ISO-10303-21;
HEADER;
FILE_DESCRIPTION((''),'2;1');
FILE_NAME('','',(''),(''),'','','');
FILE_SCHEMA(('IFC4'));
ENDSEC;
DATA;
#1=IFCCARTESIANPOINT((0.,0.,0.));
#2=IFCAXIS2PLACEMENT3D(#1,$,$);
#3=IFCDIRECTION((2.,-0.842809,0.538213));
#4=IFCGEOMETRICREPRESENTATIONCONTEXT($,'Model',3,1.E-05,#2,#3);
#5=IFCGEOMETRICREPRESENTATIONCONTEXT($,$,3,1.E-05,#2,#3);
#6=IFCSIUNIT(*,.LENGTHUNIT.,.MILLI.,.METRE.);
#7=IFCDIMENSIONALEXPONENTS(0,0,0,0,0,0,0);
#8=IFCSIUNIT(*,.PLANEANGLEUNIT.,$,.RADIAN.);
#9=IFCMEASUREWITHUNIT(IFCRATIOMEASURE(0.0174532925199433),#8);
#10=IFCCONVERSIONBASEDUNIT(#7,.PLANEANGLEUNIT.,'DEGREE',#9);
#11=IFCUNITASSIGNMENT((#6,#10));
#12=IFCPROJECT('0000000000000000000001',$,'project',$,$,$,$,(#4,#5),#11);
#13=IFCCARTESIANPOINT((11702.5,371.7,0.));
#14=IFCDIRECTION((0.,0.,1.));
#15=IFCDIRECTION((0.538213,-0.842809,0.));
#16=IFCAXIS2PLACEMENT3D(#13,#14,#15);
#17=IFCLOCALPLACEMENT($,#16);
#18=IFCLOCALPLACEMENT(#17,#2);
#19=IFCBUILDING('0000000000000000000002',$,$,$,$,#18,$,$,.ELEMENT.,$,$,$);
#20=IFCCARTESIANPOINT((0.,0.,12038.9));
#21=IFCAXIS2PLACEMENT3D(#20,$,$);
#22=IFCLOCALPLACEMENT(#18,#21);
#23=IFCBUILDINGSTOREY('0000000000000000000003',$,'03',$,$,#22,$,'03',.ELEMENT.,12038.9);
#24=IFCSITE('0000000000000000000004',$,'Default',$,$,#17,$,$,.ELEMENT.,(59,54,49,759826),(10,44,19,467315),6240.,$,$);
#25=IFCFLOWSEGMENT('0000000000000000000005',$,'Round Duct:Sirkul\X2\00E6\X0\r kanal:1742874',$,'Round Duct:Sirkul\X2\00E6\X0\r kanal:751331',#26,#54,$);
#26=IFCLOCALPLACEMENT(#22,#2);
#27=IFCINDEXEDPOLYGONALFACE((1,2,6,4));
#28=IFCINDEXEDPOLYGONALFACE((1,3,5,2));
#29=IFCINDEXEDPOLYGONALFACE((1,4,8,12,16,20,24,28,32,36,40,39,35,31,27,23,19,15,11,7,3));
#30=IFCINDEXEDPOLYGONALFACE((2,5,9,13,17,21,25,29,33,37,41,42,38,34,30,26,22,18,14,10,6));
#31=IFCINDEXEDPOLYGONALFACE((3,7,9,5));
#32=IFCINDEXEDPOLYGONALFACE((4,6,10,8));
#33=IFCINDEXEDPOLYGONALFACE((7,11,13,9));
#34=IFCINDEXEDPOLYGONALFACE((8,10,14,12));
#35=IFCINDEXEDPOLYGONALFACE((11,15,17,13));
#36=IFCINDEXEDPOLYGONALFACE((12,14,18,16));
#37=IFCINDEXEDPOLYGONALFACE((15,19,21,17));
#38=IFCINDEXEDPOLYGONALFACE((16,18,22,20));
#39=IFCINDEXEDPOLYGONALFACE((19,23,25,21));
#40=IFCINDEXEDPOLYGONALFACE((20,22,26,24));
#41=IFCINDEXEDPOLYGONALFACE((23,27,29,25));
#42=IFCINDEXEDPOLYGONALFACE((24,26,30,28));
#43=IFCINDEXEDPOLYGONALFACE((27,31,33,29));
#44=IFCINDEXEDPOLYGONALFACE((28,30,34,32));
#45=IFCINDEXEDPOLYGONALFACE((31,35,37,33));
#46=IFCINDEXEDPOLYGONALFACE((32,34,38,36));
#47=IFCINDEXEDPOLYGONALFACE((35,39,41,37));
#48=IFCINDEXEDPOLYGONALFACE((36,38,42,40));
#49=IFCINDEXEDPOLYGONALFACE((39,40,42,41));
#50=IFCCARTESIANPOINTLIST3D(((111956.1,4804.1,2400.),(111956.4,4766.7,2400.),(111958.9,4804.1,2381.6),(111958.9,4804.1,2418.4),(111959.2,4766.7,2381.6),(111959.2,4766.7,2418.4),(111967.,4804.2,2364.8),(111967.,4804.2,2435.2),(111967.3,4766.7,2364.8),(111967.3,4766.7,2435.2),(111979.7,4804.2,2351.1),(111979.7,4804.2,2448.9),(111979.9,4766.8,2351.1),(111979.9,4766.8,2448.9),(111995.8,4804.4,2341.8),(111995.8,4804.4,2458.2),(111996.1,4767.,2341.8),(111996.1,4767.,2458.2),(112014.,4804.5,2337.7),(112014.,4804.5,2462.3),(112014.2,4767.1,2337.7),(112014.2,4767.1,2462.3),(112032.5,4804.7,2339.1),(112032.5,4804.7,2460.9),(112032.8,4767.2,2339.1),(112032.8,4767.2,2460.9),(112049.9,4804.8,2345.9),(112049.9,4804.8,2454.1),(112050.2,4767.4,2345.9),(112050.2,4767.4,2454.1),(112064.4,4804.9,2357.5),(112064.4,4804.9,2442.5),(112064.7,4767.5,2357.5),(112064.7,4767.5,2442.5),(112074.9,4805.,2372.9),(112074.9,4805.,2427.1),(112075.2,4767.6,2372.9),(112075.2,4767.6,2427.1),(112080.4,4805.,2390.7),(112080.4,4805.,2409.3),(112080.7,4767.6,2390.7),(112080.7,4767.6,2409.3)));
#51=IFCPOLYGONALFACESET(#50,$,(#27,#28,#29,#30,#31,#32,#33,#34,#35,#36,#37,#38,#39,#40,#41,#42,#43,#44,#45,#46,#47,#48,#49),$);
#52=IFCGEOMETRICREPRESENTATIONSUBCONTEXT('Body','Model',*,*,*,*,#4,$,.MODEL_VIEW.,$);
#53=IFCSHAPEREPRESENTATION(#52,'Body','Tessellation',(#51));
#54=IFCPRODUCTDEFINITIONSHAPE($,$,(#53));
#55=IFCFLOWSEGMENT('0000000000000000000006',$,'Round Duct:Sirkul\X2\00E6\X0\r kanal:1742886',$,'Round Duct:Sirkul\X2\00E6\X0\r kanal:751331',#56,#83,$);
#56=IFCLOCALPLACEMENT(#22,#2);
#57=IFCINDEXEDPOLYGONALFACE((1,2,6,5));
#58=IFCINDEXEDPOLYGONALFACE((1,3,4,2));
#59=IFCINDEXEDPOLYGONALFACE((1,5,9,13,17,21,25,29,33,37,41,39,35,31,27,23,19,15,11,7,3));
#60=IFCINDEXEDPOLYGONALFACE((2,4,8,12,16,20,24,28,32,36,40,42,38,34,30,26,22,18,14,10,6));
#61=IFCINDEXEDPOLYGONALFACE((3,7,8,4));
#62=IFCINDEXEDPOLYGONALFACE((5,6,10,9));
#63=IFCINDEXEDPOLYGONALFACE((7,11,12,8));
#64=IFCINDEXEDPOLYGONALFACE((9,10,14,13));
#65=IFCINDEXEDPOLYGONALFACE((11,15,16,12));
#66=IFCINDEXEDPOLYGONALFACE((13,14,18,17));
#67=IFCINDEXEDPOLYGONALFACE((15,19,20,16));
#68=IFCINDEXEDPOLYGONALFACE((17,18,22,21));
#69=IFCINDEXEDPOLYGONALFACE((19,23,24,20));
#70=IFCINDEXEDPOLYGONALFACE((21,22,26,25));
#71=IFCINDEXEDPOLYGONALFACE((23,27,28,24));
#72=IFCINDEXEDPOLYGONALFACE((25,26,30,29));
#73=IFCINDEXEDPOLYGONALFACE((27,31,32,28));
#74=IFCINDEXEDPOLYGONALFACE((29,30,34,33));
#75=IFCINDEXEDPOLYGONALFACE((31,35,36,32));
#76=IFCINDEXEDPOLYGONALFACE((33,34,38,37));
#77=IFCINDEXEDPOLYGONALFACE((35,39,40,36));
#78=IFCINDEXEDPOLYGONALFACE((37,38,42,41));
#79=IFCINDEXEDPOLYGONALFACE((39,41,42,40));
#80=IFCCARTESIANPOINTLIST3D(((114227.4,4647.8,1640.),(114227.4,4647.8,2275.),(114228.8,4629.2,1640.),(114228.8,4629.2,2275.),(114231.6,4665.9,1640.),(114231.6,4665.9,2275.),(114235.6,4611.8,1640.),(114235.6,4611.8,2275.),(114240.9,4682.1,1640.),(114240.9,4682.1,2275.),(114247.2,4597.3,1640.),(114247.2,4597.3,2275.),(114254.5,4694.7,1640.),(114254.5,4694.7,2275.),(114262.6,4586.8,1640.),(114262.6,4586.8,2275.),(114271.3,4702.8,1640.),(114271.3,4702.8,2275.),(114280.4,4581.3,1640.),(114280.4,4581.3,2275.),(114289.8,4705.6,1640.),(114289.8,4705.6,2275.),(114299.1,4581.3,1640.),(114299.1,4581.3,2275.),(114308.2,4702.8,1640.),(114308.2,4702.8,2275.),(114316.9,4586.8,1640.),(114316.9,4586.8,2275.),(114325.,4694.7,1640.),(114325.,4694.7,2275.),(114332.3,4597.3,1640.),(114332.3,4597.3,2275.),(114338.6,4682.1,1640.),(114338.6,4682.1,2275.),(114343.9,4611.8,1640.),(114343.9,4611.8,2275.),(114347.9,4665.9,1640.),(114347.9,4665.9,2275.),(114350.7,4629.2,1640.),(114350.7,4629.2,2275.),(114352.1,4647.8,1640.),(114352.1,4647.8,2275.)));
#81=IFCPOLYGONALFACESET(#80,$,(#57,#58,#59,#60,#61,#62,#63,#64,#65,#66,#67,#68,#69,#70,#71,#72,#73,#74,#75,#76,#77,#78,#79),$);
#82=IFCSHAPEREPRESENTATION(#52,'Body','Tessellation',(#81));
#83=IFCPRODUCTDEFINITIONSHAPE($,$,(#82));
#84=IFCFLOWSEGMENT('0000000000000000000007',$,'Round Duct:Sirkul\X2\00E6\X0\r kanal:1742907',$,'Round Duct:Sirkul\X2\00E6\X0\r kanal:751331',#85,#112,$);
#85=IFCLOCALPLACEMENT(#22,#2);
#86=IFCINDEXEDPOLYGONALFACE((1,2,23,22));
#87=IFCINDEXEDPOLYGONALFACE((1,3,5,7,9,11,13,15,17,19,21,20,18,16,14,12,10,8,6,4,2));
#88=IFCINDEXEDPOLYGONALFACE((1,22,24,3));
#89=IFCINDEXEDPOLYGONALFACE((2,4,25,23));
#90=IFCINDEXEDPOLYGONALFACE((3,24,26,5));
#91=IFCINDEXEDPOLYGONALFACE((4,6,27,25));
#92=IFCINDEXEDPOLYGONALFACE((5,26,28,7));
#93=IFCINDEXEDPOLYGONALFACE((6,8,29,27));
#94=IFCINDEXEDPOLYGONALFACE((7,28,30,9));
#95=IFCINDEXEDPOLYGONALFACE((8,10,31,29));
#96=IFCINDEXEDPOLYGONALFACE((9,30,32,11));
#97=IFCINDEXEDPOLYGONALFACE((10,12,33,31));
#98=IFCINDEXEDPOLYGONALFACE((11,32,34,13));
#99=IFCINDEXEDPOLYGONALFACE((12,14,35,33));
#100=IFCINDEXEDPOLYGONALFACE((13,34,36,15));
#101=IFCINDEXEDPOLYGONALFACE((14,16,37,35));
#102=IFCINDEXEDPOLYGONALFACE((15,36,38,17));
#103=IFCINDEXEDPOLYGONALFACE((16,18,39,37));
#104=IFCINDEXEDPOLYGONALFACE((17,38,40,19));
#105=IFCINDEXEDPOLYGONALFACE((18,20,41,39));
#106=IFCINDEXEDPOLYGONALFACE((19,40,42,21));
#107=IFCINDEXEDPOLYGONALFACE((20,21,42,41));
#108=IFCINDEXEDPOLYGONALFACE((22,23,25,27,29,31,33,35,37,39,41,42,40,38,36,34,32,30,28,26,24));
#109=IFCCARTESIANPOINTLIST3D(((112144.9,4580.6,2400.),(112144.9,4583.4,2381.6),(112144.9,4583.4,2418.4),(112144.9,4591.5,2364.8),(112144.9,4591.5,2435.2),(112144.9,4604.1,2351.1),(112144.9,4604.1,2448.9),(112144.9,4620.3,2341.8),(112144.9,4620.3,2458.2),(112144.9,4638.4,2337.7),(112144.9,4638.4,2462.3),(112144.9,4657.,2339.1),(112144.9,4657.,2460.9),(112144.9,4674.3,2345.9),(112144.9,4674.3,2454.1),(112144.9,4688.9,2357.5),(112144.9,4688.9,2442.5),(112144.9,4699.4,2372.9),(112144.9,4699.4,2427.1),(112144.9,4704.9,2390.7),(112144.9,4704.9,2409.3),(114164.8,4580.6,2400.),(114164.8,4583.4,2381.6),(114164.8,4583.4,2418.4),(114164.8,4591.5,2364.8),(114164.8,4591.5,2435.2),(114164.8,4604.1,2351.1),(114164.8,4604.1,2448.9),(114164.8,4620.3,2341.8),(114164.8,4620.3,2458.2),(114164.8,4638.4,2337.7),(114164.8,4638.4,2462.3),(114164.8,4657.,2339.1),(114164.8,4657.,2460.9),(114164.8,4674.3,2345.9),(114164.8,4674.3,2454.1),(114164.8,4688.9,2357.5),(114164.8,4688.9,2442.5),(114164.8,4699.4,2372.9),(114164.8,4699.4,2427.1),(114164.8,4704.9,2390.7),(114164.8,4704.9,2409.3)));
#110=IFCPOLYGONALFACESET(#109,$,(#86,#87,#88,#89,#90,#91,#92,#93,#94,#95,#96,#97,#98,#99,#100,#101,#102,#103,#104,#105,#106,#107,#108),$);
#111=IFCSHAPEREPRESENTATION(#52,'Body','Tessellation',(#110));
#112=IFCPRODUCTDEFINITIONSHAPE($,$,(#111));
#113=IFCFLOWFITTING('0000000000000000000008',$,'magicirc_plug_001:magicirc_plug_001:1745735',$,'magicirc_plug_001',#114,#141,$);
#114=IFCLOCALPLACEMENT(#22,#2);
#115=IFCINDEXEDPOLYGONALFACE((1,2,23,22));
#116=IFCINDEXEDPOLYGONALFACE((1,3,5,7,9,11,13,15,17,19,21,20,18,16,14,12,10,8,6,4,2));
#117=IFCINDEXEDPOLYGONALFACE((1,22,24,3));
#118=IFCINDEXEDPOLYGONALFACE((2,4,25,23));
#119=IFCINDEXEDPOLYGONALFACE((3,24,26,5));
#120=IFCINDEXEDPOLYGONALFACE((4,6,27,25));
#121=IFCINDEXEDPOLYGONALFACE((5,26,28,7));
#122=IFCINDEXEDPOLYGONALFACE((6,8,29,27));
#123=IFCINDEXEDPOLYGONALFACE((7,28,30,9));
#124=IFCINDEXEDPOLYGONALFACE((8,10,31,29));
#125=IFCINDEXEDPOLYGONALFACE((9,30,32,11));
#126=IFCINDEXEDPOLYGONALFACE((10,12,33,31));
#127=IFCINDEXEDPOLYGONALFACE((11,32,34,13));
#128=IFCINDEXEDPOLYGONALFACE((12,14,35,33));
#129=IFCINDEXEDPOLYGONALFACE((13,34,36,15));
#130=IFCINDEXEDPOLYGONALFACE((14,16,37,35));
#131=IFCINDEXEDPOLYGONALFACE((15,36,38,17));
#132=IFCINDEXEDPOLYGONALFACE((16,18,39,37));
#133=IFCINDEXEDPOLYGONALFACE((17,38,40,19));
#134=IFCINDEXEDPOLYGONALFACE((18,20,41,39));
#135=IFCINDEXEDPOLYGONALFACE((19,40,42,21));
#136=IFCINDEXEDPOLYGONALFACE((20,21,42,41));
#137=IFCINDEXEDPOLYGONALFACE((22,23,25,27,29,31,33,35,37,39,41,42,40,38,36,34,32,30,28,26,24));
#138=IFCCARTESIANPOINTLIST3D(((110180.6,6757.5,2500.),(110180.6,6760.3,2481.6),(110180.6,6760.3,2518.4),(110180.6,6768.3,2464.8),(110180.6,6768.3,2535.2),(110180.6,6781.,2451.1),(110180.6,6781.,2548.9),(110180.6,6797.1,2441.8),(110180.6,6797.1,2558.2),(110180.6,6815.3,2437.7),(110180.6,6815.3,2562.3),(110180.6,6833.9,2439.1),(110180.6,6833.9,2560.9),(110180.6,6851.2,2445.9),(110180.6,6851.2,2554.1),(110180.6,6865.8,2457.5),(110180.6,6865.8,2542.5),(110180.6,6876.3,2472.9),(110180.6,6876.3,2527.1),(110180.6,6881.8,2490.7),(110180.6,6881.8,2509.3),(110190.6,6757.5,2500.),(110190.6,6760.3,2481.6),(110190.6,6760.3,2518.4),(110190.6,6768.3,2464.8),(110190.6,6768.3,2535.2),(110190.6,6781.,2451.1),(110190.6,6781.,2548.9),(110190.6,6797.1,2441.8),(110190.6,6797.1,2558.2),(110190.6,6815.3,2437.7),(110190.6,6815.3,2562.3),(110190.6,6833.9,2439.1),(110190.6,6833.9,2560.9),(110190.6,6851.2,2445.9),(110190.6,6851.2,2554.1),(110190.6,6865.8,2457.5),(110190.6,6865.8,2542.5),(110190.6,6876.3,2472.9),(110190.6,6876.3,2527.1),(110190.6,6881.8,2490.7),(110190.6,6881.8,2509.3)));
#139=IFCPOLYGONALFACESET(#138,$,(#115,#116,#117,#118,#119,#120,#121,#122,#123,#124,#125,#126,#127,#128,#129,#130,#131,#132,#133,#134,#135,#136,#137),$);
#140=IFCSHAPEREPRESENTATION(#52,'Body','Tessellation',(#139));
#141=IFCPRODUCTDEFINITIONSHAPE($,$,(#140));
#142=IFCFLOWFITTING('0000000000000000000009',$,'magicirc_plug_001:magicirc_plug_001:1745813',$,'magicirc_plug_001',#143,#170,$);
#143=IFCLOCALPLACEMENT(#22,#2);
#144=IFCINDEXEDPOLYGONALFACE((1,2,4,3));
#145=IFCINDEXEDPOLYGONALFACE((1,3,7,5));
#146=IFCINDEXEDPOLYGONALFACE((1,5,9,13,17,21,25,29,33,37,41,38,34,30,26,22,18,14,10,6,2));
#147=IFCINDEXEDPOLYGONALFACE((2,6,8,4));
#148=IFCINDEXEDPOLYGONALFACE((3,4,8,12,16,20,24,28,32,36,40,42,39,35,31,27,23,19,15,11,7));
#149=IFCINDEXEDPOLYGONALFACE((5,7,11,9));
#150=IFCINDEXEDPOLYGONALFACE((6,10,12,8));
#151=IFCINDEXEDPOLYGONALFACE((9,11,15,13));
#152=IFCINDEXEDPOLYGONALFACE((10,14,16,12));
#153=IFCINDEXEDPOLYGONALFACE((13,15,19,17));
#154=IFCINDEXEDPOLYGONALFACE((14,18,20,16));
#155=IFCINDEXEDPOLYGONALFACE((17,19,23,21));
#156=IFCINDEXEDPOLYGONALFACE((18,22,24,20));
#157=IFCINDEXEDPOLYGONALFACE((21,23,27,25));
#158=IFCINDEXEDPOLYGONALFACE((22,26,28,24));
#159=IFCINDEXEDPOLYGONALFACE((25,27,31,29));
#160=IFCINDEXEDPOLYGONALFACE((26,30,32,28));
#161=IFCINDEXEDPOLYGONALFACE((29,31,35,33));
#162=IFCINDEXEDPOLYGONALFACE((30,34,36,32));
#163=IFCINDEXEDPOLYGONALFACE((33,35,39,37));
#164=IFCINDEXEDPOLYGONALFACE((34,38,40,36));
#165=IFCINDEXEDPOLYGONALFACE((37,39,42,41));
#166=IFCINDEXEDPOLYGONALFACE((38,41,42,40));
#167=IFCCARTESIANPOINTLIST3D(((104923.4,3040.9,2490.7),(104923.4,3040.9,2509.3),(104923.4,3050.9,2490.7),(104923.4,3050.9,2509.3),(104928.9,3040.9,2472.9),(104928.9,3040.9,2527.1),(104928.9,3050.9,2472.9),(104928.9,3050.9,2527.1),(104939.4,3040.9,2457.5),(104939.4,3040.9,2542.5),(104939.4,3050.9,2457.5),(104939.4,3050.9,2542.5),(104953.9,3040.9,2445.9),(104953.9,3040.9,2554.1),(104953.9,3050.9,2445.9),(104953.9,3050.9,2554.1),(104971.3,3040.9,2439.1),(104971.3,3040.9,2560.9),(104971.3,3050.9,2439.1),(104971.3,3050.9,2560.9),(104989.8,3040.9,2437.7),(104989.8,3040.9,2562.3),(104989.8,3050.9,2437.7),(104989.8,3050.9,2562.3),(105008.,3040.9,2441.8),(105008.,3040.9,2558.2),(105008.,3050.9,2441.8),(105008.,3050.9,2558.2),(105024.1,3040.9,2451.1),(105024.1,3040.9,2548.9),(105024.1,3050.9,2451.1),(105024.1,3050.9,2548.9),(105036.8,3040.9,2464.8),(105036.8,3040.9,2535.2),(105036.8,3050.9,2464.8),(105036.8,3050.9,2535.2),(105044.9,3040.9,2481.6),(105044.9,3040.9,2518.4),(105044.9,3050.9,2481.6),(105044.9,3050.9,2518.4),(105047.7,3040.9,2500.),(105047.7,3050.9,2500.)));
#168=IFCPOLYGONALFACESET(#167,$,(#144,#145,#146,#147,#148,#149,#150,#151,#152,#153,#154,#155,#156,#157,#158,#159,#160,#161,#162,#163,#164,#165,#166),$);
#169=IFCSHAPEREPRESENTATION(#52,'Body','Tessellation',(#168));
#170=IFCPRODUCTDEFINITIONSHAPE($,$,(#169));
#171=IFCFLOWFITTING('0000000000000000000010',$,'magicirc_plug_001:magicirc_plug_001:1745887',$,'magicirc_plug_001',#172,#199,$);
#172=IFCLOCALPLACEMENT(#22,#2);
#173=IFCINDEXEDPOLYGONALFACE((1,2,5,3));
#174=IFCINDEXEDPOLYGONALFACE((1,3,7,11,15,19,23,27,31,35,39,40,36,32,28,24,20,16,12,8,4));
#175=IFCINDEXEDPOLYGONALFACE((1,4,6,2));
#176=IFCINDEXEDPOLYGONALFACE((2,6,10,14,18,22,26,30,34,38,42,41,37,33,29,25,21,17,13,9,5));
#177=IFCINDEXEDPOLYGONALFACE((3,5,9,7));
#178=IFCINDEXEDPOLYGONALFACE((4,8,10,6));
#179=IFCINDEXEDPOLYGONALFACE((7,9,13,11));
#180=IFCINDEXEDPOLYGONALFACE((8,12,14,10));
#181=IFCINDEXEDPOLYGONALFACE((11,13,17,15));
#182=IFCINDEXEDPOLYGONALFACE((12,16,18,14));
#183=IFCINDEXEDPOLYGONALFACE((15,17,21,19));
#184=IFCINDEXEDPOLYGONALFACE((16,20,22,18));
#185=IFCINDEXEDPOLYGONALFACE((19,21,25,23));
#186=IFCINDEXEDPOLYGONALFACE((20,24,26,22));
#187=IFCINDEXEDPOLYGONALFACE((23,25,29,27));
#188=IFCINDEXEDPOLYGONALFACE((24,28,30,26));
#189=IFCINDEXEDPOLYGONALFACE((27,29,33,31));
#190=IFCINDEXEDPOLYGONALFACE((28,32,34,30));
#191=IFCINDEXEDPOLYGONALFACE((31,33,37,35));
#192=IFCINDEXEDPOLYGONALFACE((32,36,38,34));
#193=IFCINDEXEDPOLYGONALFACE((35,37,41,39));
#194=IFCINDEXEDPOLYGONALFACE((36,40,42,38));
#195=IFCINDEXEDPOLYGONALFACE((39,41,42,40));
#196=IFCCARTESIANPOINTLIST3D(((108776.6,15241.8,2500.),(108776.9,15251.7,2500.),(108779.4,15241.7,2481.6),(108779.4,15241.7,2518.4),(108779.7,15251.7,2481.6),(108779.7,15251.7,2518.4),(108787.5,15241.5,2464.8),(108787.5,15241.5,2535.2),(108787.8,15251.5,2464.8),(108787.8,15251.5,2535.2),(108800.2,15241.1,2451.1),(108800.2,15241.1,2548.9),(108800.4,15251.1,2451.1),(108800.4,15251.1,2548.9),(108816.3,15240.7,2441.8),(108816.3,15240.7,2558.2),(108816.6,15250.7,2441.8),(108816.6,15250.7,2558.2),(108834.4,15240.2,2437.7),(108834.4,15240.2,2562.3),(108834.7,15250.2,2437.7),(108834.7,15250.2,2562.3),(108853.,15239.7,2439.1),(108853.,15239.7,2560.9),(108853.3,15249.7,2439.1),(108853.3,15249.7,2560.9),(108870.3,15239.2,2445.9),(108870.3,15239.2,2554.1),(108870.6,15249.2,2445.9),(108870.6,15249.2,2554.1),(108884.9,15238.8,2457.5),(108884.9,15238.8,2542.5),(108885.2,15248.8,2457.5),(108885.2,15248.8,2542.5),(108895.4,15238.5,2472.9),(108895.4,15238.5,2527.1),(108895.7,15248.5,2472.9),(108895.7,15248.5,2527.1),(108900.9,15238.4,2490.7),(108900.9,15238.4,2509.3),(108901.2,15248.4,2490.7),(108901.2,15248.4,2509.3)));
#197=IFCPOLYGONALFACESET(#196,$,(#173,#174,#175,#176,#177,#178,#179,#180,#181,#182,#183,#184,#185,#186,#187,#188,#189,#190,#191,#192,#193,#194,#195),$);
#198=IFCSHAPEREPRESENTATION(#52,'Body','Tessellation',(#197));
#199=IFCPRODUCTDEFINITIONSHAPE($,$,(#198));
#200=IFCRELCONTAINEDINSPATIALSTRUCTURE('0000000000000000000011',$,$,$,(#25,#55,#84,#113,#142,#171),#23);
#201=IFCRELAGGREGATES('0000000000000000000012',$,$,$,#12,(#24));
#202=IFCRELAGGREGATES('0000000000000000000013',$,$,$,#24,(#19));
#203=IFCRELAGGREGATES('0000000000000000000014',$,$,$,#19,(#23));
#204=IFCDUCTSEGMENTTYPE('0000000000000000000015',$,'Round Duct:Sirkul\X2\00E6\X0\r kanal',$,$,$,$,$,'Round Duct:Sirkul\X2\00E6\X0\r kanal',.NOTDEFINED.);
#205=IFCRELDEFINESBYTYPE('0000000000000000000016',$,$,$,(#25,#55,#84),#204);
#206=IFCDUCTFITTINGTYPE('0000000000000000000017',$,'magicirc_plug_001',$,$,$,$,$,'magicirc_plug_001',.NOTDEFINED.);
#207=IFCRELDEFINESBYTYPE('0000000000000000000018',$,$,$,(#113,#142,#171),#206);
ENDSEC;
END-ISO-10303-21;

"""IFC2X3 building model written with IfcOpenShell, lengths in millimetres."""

from ifc_helpers import new_model, entity, si_unit, converted_unit, direction, frame, frame_2d, origin, origin_2d_with_axis, place, context, subcontext, project, spatial, circle, extrude, source, transform, mapped, type_object, type_shapes, element, save


model = new_model("IFC2X3")

# Units and contexts
model_context = context("Model", 3, precision=1e-05, world=origin(), true_north=direction((2.0, -0.842809, 0.538213)))
context_of_model = context(None, 3, precision=1e-05, world=origin(), true_north=direction((2.0, -0.842809, 0.538213)))
body_context = subcontext(model_context, "Body", "Model", "MODEL_VIEW")
ifc_project = project(units=[si_unit("LENGTHUNIT", "METRE", prefix="MILLI"), converted_unit("PLANEANGLEUNIT", "DEGREE", entity("IfcRatioMeasure", 0.0174532925199433), si_unit("PLANEANGLEUNIT", "RADIAN"), dimensions=[0, 0, 0, 0, 0, 0, 0])], contexts=[model_context, context_of_model])

# Site, building, storey
site_placement = place(None, frame((11702.5, 371.7, 0.0), z_axis=(0.0, 0.0, 1.0), x_axis=(0.538213, -0.842809, 0.0)))
site = spatial("IfcSite", under=ifc_project, at=site_placement, Name="Default", CompositionType="ELEMENT", RefLatitude=(59, 54, 49, 759826), RefLongitude=(10, 44, 19, 467315), RefElevation=6240.0)
building_placement = place(site_placement, origin())
building = spatial("IfcBuilding", under=site, at=building_placement, CompositionType="ELEMENT")
storey_placement = place(building_placement, frame((0.0, 0.0, 12038.9)))
storey = spatial("IfcBuildingStorey", under=building, at=storey_placement, Name="03", LongName="03", CompositionType="ELEMENT", Elevation=12038.9)

# Flow segments
duct_segment_type = type_object("IfcDuctSegmentType", Name="Round Duct:Sirkulær kanal", ElementType="Round Duct:Sirkulær kanal", PredefinedType="NOTDEFINED")
flow_segment_1_placement = place(storey_placement, origin())
element("IfcFlowSegment", 1, at=flow_segment_1_placement, inside=storey, type_object=duct_segment_type, Name="Round Duct:Sirkulær kanal:1742874", ObjectType="Round Duct:Sirkulær kanal:751331", context=body_context, shape_type="SweptSolid", body=[
    extrude(circle(Radius=62.5, at=frame_2d((0.0, 0.0), x_axis=(1.0, 0.0))), frame((112018.6, 4804.5, 2400.0), z_axis=(0.007643, -0.999971, 0.0), x_axis=(-0.999971, -0.007643, 0.0)), (0.0, 0.0, 1.0), 37.4),
])
flow_segment_2_placement = place(storey_placement, origin())
element("IfcFlowSegment", 2, at=flow_segment_2_placement, inside=storey, type_object=duct_segment_type, Name="Round Duct:Sirkulær kanal:1742886", ObjectType="Round Duct:Sirkulær kanal:751331", context=body_context, shape_type="SweptSolid", body=[
    extrude(circle(Radius=62.5, at=origin_2d_with_axis()), frame((114289.8, 4643.1, 1640.0), z_axis=(0.0, 0.0, 1.0), x_axis=(0.0, 1.0, 0.0)), (0.0, 0.0, 1.0), 635.0),
])
flow_segment_3_placement = place(storey_placement, origin())
element("IfcFlowSegment", 3, at=flow_segment_3_placement, inside=storey, type_object=duct_segment_type, Name="Round Duct:Sirkulær kanal:1742907", ObjectType="Round Duct:Sirkulær kanal:751331", context=body_context, shape_type="SweptSolid", body=[
    extrude(circle(Radius=62.5, at=frame_2d((0.0, 0.0), x_axis=(1.0, 0.0))), frame((112144.9, 4643.1, 2400.0), z_axis=(1.0, 0.0, 0.0), x_axis=(0.0, -1.0, 0.0)), (0.0, 0.0, 1.0), 2019.9),
])

# Flow fittings
duct_fitting_type_1 = type_object("IfcDuctFittingType", Name="magicirc_plug_001", ElementType="magicirc_plug_001", PredefinedType="NOTDEFINED")
shared_shape_1 = source(origin(), body_context, "Body", "SweptSolid", [
    extrude(circle(Radius=62.5, at=frame_2d((0.0, 0.0), x_axis=(1.0, 0.0))), frame((0.0, 0.0, 0.0), z_axis=(1.0, 0.0, 0.0), x_axis=(0.0, 1.0, 0.0)), (0.0, 0.0, 1.0), 10.0),
])
type_shapes(duct_fitting_type_1, [shared_shape_1])
for number, where, z_axis, x_axis, name in (
    (4, (110190.6, 6820.0, 2500.0), (0.0, 0.0, 1.0), (-1.0, 0.0, 0.0), "magicirc_plug_001:magicirc_plug_001:1745735"),
    (5, (104985.2, 3050.9, 2500.0), (0.0, 0.0, 1.0), (0.0, -1.0, 0.0), "magicirc_plug_001:magicirc_plug_001:1745813"),
    (6, (108839.1, 15240.0, 2500.0), (0.0, 0.0, 1.0), (0.02726, 0.999628, 0.0), "magicirc_plug_001:magicirc_plug_001:1745887"),
):
    element("IfcFlowFitting", number, at=place(storey_placement, frame(where, z_axis=z_axis, x_axis=x_axis)), inside=storey, type_object=duct_fitting_type_1, Name=name, ObjectType="magicirc_plug_001", context=body_context, shape_type="MappedRepresentation", body=[
        mapped(shared_shape_1, transform((0.0, 0.0, 0.0), scale=1.0)),
    ])

save(model, "model.ifc")
